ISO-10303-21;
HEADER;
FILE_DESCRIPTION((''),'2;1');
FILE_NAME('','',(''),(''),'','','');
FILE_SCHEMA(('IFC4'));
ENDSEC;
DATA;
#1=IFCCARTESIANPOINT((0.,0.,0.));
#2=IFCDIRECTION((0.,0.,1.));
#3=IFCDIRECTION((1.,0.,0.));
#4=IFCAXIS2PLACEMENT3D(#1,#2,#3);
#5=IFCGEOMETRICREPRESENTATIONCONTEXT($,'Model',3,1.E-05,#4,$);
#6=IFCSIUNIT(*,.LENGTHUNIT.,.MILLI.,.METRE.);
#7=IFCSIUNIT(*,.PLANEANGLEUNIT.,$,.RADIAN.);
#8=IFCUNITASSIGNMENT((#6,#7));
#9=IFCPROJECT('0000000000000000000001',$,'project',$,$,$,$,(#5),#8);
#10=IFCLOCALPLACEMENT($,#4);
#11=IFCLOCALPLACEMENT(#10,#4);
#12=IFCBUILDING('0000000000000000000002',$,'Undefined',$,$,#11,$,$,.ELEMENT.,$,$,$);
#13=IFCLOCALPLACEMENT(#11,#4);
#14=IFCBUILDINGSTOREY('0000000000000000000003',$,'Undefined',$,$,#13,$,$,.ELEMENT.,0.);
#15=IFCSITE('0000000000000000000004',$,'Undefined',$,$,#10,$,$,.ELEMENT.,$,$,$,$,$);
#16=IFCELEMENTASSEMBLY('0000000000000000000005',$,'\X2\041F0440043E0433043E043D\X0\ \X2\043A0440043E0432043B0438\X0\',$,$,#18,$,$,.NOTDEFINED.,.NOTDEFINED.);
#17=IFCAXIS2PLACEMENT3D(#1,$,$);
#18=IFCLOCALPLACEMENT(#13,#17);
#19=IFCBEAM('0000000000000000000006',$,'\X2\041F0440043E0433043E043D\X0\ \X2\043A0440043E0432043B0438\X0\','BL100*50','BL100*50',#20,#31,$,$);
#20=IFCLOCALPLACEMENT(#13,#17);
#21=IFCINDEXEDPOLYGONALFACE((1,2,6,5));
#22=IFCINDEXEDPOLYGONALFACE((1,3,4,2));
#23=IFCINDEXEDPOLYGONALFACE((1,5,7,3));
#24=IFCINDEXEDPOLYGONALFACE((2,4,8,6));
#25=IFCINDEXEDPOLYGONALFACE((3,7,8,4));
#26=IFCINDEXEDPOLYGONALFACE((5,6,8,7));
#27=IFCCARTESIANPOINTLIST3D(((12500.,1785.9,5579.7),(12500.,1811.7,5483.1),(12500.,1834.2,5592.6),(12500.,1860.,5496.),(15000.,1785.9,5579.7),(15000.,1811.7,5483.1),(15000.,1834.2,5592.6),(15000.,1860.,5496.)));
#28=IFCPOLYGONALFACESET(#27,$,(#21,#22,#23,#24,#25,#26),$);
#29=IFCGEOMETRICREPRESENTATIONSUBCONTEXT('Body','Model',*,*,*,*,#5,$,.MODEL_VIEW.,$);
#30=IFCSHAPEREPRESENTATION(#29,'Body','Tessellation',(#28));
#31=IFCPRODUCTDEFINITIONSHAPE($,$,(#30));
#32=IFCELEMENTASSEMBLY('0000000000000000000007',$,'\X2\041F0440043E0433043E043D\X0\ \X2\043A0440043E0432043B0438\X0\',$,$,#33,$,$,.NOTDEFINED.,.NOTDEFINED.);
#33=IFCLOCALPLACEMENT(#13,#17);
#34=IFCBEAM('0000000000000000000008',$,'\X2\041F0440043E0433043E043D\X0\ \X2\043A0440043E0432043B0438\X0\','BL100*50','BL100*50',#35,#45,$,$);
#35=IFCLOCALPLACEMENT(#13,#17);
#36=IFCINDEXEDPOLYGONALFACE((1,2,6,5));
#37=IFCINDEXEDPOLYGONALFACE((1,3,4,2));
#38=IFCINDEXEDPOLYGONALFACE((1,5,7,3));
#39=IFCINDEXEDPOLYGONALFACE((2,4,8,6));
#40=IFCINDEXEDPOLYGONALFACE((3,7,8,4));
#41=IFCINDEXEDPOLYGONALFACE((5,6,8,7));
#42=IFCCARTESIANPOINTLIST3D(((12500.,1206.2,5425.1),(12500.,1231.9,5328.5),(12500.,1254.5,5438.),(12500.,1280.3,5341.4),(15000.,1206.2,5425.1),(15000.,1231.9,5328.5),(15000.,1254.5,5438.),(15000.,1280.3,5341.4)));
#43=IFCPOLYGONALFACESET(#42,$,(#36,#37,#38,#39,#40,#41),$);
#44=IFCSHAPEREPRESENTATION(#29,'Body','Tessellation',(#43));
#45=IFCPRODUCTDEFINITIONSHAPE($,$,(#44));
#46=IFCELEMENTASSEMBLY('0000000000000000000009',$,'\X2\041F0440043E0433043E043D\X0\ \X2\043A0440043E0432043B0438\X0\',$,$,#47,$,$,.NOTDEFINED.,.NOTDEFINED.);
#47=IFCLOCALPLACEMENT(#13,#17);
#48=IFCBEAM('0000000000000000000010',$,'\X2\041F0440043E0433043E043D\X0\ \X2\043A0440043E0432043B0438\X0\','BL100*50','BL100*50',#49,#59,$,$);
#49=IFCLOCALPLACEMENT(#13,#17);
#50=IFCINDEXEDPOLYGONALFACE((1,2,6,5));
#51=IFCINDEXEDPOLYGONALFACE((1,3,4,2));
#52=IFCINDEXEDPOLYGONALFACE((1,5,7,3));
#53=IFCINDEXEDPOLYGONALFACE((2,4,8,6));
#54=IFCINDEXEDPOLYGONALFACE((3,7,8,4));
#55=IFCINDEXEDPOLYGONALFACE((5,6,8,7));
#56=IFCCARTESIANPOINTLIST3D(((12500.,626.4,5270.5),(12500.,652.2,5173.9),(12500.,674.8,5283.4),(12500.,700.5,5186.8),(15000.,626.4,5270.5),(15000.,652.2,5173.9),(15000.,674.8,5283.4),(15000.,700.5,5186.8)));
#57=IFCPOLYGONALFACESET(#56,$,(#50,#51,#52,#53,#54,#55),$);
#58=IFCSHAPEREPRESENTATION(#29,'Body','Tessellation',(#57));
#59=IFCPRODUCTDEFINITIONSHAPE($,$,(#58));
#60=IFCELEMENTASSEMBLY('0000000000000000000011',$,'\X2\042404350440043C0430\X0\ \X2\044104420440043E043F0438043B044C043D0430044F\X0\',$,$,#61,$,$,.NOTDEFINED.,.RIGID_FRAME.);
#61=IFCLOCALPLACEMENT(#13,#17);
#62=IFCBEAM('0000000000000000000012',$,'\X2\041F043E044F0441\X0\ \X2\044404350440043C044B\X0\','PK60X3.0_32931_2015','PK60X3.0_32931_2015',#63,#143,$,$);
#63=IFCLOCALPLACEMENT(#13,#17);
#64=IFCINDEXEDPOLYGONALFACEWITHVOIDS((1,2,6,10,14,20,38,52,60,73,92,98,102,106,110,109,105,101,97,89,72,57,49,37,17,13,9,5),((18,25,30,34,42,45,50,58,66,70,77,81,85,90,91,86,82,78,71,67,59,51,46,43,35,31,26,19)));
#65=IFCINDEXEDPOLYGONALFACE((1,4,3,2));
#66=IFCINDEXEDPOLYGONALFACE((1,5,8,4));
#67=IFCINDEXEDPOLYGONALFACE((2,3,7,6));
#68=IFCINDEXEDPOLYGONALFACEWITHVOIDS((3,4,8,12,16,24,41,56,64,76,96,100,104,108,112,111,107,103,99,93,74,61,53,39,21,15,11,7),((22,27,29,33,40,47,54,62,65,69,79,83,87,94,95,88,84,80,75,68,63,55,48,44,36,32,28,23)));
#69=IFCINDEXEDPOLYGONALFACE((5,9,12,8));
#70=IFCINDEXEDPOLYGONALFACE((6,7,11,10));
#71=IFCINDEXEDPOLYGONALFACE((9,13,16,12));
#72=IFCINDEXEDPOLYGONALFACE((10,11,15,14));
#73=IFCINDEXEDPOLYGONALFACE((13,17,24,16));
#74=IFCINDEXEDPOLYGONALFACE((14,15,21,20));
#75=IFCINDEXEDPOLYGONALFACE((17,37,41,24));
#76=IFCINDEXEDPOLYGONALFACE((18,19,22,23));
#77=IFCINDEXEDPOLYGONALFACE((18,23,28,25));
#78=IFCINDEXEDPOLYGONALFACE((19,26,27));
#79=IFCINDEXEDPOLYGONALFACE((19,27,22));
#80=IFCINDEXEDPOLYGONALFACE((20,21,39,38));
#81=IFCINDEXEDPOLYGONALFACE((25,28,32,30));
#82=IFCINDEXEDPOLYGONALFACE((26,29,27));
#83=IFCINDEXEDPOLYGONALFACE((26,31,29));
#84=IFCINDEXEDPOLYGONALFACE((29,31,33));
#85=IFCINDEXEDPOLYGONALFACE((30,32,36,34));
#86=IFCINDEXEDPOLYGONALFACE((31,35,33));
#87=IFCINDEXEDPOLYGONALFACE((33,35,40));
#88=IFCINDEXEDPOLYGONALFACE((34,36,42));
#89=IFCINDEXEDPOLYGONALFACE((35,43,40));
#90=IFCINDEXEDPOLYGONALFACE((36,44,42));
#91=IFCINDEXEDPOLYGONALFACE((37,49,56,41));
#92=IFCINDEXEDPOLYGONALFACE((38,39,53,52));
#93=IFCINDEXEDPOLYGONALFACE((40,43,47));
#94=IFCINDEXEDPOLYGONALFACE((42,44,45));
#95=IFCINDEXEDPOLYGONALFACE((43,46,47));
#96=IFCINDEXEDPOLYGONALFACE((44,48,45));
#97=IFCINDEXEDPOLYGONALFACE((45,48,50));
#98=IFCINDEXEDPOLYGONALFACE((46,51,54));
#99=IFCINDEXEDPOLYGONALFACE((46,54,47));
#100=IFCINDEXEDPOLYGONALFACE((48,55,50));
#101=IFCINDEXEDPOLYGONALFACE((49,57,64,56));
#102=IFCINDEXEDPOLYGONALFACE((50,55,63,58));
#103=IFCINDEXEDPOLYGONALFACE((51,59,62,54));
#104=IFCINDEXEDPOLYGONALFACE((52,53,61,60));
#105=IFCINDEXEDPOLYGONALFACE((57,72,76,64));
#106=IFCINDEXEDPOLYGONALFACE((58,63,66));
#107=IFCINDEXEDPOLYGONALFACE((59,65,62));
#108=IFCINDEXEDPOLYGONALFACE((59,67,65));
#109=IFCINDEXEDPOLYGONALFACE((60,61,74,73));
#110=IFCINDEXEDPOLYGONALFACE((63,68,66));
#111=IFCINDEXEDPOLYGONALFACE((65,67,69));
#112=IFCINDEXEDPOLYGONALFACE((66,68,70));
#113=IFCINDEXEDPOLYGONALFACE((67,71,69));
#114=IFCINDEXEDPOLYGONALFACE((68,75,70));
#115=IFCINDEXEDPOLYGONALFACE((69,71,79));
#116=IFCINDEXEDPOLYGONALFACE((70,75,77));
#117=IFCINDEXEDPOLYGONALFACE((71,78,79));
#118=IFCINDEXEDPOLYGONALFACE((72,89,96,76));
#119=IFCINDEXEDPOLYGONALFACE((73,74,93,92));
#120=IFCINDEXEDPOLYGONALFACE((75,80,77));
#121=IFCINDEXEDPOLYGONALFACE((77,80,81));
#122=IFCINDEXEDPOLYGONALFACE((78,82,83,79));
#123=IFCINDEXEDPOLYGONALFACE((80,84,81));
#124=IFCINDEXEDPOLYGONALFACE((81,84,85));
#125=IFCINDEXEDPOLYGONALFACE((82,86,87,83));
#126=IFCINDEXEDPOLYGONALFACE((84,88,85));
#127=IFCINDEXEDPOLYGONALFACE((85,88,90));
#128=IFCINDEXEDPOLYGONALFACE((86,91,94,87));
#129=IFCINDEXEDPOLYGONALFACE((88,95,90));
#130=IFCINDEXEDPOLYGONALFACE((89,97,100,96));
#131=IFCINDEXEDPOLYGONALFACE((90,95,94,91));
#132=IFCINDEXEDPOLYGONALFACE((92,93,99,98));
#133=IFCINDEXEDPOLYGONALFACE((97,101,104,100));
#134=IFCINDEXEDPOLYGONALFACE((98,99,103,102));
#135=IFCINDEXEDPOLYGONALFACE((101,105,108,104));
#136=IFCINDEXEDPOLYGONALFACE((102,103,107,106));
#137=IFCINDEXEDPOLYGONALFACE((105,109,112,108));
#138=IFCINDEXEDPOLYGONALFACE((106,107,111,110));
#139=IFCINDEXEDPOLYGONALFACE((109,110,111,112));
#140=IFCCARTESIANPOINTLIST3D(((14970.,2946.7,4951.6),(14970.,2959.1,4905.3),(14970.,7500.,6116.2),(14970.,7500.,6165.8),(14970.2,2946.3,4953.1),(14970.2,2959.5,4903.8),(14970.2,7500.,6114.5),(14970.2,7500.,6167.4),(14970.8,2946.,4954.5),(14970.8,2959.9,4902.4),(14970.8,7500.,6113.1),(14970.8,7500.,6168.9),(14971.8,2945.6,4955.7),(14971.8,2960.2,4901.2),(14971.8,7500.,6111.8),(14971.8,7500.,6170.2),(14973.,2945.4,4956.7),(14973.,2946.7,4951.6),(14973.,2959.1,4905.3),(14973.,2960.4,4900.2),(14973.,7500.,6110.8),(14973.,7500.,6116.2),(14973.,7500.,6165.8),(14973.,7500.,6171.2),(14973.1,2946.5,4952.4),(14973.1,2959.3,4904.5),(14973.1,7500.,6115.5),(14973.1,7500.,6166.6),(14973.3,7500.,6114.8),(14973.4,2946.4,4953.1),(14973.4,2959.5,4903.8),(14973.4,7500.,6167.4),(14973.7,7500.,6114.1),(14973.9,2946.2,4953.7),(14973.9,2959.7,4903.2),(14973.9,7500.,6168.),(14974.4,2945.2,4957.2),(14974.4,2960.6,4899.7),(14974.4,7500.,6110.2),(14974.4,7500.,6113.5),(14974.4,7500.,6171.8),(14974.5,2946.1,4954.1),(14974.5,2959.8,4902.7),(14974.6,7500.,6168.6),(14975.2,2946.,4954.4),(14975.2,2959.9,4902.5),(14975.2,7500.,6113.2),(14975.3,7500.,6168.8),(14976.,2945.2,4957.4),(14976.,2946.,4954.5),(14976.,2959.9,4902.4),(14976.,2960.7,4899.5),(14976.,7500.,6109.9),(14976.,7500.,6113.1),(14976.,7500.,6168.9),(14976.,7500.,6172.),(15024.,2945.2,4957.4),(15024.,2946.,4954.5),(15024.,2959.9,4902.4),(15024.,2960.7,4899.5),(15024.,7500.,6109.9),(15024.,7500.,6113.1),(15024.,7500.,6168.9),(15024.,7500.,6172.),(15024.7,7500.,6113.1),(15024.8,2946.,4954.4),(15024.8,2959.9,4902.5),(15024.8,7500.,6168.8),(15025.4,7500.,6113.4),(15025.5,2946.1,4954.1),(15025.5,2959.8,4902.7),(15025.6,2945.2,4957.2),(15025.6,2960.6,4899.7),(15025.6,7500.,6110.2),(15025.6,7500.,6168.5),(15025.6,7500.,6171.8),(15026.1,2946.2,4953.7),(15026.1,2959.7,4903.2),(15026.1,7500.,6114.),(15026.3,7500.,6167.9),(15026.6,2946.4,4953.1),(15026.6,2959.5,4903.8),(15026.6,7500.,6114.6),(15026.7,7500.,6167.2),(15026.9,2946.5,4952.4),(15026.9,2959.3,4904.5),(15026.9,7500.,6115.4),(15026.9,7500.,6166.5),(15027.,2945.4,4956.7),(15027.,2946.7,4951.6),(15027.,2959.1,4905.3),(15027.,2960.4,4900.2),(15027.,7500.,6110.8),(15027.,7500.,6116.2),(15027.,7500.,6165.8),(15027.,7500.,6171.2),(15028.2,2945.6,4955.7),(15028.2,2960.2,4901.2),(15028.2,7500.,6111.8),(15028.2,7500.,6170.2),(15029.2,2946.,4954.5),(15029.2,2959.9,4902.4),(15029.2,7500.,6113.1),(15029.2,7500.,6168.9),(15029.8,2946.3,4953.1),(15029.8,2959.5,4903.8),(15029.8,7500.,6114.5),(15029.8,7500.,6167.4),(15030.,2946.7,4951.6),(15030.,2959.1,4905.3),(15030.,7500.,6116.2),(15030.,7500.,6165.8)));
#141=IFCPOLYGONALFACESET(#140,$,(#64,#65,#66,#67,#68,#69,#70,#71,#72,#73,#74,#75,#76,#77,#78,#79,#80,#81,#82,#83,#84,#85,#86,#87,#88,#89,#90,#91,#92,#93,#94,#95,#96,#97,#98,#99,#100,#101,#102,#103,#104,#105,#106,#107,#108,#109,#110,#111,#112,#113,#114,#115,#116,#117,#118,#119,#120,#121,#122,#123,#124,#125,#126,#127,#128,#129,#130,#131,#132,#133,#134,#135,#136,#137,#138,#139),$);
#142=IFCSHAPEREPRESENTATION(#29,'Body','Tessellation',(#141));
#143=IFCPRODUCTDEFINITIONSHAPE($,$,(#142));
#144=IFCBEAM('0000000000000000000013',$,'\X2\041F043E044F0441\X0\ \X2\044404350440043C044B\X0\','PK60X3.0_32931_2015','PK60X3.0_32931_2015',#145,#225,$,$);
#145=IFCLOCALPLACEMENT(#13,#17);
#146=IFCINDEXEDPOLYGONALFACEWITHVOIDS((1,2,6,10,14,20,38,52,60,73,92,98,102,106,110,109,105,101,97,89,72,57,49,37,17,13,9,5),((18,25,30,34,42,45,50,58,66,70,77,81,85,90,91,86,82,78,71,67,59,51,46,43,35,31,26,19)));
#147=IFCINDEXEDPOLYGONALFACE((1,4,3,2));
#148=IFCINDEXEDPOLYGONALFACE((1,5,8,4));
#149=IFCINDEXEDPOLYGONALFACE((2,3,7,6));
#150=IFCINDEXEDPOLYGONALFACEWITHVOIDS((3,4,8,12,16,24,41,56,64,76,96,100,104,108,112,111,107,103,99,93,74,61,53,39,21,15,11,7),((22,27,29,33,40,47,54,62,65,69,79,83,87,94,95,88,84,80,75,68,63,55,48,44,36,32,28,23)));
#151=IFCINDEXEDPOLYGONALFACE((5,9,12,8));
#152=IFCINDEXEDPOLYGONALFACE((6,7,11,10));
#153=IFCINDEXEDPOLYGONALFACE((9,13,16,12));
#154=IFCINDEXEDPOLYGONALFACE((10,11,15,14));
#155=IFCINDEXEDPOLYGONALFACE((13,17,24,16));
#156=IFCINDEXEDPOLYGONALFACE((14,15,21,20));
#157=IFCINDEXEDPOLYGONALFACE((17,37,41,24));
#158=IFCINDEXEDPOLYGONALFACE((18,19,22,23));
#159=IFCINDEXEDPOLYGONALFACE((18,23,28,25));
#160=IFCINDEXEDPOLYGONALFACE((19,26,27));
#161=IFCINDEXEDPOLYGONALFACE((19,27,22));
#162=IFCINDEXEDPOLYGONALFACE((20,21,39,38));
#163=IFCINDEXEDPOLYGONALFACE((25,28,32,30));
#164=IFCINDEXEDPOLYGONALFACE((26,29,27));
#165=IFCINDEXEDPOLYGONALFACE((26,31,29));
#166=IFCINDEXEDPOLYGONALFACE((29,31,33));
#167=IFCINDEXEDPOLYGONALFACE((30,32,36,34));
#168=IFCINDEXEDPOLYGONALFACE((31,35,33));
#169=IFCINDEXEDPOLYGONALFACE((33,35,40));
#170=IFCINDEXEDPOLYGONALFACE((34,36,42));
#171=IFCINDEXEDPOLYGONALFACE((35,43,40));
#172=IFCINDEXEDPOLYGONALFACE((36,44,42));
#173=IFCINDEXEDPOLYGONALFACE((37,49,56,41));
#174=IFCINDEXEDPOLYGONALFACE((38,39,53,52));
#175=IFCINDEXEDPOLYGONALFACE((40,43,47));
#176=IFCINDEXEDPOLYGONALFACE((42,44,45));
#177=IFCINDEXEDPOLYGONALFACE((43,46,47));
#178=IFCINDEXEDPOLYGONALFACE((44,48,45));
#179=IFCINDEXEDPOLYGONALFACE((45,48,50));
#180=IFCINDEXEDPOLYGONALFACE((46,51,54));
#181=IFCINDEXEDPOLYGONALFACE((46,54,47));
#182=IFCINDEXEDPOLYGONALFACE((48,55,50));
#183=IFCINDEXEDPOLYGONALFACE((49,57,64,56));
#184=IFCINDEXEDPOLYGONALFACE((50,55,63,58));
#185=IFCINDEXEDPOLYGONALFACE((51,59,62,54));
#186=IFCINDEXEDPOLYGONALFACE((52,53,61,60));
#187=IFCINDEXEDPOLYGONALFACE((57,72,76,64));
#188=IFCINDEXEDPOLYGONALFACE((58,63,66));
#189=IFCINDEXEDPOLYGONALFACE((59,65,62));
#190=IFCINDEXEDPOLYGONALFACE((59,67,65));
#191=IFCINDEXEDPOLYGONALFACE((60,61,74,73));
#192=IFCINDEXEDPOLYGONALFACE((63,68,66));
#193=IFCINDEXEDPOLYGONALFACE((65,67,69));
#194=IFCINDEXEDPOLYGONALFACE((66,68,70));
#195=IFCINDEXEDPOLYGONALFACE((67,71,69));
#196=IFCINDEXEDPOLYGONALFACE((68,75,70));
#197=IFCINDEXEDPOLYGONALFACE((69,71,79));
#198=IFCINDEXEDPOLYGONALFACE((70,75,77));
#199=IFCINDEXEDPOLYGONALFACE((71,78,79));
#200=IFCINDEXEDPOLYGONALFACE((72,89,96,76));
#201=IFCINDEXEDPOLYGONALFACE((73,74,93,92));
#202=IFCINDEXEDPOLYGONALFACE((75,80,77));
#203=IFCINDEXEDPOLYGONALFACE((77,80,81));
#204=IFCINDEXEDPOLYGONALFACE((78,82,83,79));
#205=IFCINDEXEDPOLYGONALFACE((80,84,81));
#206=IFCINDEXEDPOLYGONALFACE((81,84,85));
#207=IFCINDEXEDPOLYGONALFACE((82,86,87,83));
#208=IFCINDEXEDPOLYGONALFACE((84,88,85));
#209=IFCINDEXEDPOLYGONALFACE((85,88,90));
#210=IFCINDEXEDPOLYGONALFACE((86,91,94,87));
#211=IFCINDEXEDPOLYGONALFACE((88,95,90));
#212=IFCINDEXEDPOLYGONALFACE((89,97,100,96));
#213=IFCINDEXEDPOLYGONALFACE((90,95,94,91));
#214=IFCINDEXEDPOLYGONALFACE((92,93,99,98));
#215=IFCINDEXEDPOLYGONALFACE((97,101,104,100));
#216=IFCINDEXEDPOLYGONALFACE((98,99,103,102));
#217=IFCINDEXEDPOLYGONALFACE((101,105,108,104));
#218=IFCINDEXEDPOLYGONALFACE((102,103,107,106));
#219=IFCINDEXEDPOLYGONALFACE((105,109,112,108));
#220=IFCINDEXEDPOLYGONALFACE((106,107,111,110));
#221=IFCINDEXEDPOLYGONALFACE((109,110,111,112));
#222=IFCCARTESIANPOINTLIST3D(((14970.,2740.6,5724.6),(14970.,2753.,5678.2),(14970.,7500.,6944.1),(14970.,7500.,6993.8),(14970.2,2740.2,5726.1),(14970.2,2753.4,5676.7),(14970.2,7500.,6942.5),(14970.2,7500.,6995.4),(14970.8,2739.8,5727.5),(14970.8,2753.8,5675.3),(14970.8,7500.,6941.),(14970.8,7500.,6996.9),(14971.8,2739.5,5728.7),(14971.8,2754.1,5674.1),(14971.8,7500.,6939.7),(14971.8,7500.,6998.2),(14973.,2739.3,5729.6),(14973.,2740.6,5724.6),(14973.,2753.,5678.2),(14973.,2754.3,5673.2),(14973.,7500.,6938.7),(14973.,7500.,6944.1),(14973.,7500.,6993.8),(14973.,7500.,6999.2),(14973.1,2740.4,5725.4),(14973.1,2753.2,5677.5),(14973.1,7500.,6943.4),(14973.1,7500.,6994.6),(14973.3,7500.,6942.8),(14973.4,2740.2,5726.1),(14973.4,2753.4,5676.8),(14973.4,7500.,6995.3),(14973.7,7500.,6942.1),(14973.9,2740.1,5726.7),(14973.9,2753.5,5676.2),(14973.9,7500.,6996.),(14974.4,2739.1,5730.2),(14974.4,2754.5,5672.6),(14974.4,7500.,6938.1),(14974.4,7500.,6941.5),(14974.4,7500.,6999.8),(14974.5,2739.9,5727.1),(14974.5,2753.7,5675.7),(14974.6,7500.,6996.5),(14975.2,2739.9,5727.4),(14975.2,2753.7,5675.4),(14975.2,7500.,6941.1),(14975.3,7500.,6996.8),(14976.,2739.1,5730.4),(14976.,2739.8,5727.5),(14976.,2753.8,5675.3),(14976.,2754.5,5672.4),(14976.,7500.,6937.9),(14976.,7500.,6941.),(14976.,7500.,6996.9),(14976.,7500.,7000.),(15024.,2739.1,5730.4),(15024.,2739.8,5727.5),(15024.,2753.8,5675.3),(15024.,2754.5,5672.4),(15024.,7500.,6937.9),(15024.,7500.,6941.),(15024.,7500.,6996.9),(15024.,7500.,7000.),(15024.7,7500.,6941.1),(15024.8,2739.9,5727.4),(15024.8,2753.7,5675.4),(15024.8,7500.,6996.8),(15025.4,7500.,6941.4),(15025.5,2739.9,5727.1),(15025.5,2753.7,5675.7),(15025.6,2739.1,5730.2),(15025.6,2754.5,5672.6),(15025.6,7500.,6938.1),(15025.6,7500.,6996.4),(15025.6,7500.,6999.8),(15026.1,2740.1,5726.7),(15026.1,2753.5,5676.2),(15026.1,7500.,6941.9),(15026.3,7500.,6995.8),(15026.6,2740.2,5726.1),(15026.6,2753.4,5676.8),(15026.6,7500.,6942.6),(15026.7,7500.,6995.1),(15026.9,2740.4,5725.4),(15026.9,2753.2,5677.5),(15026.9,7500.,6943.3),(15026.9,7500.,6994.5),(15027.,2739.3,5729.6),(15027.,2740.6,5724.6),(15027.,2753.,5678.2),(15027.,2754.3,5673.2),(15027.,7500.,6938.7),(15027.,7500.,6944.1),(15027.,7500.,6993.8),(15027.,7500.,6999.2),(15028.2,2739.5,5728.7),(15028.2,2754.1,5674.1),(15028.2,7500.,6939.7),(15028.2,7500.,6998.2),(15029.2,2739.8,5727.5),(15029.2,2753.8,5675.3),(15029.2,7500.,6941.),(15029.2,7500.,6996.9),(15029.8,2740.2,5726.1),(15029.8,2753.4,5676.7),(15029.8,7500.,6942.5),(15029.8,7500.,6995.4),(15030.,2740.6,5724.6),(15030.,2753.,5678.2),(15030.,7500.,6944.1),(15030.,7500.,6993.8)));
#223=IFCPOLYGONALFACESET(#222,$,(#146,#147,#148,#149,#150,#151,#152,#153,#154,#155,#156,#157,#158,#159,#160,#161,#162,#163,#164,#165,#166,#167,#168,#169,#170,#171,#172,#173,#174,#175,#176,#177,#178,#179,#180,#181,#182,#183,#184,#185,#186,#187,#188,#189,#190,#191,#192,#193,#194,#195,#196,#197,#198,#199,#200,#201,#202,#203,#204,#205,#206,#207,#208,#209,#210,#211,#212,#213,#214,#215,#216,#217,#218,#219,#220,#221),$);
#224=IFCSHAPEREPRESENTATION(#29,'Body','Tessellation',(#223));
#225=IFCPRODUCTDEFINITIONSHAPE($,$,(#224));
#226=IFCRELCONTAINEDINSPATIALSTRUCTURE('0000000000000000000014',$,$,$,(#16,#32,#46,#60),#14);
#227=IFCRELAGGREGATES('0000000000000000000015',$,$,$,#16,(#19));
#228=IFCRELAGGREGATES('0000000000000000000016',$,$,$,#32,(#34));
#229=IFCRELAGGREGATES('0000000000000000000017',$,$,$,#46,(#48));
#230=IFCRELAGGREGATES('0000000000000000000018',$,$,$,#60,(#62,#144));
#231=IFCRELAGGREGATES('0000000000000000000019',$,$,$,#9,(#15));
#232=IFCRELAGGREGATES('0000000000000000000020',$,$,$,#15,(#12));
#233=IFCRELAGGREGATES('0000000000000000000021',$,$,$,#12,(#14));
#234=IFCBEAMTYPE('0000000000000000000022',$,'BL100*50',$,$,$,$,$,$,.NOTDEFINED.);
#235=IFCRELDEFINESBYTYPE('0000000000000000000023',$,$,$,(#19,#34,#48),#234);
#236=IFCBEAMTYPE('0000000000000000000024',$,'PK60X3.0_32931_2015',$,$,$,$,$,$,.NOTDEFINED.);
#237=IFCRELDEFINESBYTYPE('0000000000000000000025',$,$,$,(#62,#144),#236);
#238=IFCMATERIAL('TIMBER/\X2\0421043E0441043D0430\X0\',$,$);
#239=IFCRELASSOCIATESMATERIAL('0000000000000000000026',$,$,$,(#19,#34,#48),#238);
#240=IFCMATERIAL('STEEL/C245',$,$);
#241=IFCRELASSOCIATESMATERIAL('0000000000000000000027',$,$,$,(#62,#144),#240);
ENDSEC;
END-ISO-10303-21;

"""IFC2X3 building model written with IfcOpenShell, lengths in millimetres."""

from ifc_helpers import new_model, si_unit, frame, origin_with_axes, origin_2d_with_axis, place, context, subcontext, project, spatial, rectangle, hollow_rectangle, extrude, clip, halfspace, material, type_object, element, aggregate, save


model = new_model("IFC2X3")

# Units and contexts
model_context = context("Model", 3, precision=1e-05, world=origin_with_axes())
body_context = subcontext(model_context, "Body", "Model", "MODEL_VIEW")
ifc_project = project(units=[si_unit("LENGTHUNIT", "METRE", prefix="MILLI"), si_unit("PLANEANGLEUNIT", "RADIAN")], contexts=[model_context])

# Site, building, storey
site_placement = place(None, origin_with_axes())
site = spatial("IfcSite", under=ifc_project, at=site_placement, Name="Undefined", CompositionType="ELEMENT")
building_placement = place(site_placement, origin_with_axes())
building = spatial("IfcBuilding", under=site, at=building_placement, Name="Undefined", CompositionType="ELEMENT")
storey_placement = place(building_placement, origin_with_axes())
storey = spatial("IfcBuildingStorey", under=building, at=storey_placement, Name="Undefined", CompositionType="ELEMENT", Elevation=0.0)

# Shared definitions
ifc_material_1 = material(Name="STEEL/C245")

# Element assemblies, beams
ifc_material_2 = material(Name="TIMBER/Сосна")
beam_type_1 = type_object("IfcBeamType", Name="BL100*50", PredefinedType="NOTDEFINED")
assembly_1_placement = place(storey_placement, origin_with_axes())
assembly_1 = element("IfcElementAssembly", 1, at=assembly_1_placement, inside=storey, Name="Прогон кровли", AssemblyPlace="NOTDEFINED", PredefinedType="NOTDEFINED")
beam_1_placement = place(assembly_1_placement, frame((12500.0, 1823.0, 5537.9), z_axis=(0.0, 0.257663, -0.966235), x_axis=(1.0, 0.0, 0.0)))
beam_1 = element("IfcBeam", 2, at=beam_1_placement, type_object=beam_type_1, material=ifc_material_2, Name="Прогон кровли", Description="BL100*50", ObjectType="BL100*50", context=body_context, shape_type="SweptSolid", body=[
    extrude(rectangle(XDim=50.0, YDim=100.0, at=origin_2d_with_axis()), frame((2500.0, 0.0, 0.0), z_axis=(-1.0, 0.0, 0.0), x_axis=(0.0, -1.0, 0.0)), (0.0, 0.0, 1.0), 2500.0),
])
aggregate(assembly_1, [beam_1])
assembly_2_placement = place(storey_placement, origin_with_axes())
assembly_2 = element("IfcElementAssembly", 3, at=assembly_2_placement, inside=storey, Name="Прогон кровли", AssemblyPlace="NOTDEFINED", PredefinedType="NOTDEFINED")
beam_2_placement = place(assembly_2_placement, frame((12500.0, 1243.2, 5383.3), z_axis=(0.0, 0.257663, -0.966235), x_axis=(1.0, 0.0, 0.0)))
beam_2 = element("IfcBeam", 4, at=beam_2_placement, type_object=beam_type_1, material=ifc_material_2, Name="Прогон кровли", Description="BL100*50", ObjectType="BL100*50", context=body_context, shape_type="SweptSolid", body=[
    extrude(rectangle(XDim=50.0, YDim=100.0, at=origin_2d_with_axis()), frame((2500.0, 0.0, 0.0), z_axis=(-1.0, 0.0, 0.0), x_axis=(0.0, -1.0, 0.0)), (0.0, 0.0, 1.0), 2500.0),
])
aggregate(assembly_2, [beam_2])
assembly_3_placement = place(storey_placement, origin_with_axes())
assembly_3 = element("IfcElementAssembly", 5, at=assembly_3_placement, inside=storey, Name="Прогон кровли", AssemblyPlace="NOTDEFINED", PredefinedType="NOTDEFINED")
beam_3_placement = place(assembly_3_placement, frame((12500.0, 663.5, 5228.7), z_axis=(0.0, 0.257663, -0.966235), x_axis=(1.0, 0.0, 0.0)))
beam_3 = element("IfcBeam", 6, at=beam_3_placement, type_object=beam_type_1, material=ifc_material_2, Name="Прогон кровли", Description="BL100*50", ObjectType="BL100*50", context=body_context, shape_type="SweptSolid", body=[
    extrude(rectangle(XDim=50.0, YDim=100.0, at=origin_2d_with_axis()), frame((2500.0, 0.0, 0.0), z_axis=(-1.0, 0.0, 0.0), x_axis=(0.0, -1.0, 0.0)), (0.0, 0.0, 1.0), 2500.0),
])
aggregate(assembly_3, [beam_3])

# Element assembly, beams
assembly_4_placement = place(storey_placement, origin_with_axes())
assembly_4 = element("IfcElementAssembly", 7, at=assembly_4_placement, inside=storey, Name="Ферма стропильная", AssemblyPlace="NOTDEFINED", PredefinedType="RIGID_FRAME")
beam_type_2 = type_object("IfcBeamType", Name="PK60X3.0_32931_2015", PredefinedType="NOTDEFINED")
beam_4_placement = place(assembly_4_placement, frame((15000.0, 2952.9, 4928.4), z_axis=(0.0, -0.257663, 0.966235), x_axis=(0.0, 0.966235, 0.257663)))
beam_4 = element("IfcBeam", 8, at=beam_4_placement, type_object=beam_type_2, material=ifc_material_1, Name="Пояс фермы", Description="PK60X3.0_32931_2015", ObjectType="PK60X3.0_32931_2015", context=body_context, shape_type="Clipping", body=[
    clip(extrude(hollow_rectangle(XDim=60.0, YDim=60.0, WallThickness=3.0, InnerFilletRadius=3.0, OuterFilletRadius=6.0, at=origin_2d_with_axis()), frame((4729.1, 0.0, 0.0), z_axis=(-1.0, 0.0, 0.0), x_axis=(0.0, -1.0, 0.0)), (0.0, 0.0, 1.0), 4729.1), halfspace(frame((4938.1, 0.0, 870.5), z_axis=(0.966235, 0.0, -0.257663), x_axis=(0.0, -1.0, 0.0)), False)),
])
beam_5_placement = place(assembly_4_placement, frame((15000.0, 2746.8, 5701.4), z_axis=(0.0, -0.257663, 0.966235), x_axis=(0.0, 0.966235, 0.257663)))
beam_5 = element("IfcBeam", 9, at=beam_5_placement, type_object=beam_type_2, material=ifc_material_1, Name="Пояс фермы", Description="PK60X3.0_32931_2015", ObjectType="PK60X3.0_32931_2015", context=body_context, shape_type="Clipping", body=[
    clip(extrude(hollow_rectangle(XDim=60.0, YDim=60.0, WallThickness=3.0, InnerFilletRadius=3.0, OuterFilletRadius=6.0, at=origin_2d_with_axis()), frame((4942.5, 0.0, 0.0), z_axis=(-1.0, 0.0, 0.0), x_axis=(0.0, -1.0, 0.0)), (0.0, 0.0, 1.0), 4942.5), halfspace(frame((4938.1, 0.0, 70.5), z_axis=(0.966235, 0.0, -0.257663), x_axis=(0.0, -1.0, 0.0)), False)),
])

aggregate(assembly_4, [beam_4, beam_5])

save(model, "model.ifc")
